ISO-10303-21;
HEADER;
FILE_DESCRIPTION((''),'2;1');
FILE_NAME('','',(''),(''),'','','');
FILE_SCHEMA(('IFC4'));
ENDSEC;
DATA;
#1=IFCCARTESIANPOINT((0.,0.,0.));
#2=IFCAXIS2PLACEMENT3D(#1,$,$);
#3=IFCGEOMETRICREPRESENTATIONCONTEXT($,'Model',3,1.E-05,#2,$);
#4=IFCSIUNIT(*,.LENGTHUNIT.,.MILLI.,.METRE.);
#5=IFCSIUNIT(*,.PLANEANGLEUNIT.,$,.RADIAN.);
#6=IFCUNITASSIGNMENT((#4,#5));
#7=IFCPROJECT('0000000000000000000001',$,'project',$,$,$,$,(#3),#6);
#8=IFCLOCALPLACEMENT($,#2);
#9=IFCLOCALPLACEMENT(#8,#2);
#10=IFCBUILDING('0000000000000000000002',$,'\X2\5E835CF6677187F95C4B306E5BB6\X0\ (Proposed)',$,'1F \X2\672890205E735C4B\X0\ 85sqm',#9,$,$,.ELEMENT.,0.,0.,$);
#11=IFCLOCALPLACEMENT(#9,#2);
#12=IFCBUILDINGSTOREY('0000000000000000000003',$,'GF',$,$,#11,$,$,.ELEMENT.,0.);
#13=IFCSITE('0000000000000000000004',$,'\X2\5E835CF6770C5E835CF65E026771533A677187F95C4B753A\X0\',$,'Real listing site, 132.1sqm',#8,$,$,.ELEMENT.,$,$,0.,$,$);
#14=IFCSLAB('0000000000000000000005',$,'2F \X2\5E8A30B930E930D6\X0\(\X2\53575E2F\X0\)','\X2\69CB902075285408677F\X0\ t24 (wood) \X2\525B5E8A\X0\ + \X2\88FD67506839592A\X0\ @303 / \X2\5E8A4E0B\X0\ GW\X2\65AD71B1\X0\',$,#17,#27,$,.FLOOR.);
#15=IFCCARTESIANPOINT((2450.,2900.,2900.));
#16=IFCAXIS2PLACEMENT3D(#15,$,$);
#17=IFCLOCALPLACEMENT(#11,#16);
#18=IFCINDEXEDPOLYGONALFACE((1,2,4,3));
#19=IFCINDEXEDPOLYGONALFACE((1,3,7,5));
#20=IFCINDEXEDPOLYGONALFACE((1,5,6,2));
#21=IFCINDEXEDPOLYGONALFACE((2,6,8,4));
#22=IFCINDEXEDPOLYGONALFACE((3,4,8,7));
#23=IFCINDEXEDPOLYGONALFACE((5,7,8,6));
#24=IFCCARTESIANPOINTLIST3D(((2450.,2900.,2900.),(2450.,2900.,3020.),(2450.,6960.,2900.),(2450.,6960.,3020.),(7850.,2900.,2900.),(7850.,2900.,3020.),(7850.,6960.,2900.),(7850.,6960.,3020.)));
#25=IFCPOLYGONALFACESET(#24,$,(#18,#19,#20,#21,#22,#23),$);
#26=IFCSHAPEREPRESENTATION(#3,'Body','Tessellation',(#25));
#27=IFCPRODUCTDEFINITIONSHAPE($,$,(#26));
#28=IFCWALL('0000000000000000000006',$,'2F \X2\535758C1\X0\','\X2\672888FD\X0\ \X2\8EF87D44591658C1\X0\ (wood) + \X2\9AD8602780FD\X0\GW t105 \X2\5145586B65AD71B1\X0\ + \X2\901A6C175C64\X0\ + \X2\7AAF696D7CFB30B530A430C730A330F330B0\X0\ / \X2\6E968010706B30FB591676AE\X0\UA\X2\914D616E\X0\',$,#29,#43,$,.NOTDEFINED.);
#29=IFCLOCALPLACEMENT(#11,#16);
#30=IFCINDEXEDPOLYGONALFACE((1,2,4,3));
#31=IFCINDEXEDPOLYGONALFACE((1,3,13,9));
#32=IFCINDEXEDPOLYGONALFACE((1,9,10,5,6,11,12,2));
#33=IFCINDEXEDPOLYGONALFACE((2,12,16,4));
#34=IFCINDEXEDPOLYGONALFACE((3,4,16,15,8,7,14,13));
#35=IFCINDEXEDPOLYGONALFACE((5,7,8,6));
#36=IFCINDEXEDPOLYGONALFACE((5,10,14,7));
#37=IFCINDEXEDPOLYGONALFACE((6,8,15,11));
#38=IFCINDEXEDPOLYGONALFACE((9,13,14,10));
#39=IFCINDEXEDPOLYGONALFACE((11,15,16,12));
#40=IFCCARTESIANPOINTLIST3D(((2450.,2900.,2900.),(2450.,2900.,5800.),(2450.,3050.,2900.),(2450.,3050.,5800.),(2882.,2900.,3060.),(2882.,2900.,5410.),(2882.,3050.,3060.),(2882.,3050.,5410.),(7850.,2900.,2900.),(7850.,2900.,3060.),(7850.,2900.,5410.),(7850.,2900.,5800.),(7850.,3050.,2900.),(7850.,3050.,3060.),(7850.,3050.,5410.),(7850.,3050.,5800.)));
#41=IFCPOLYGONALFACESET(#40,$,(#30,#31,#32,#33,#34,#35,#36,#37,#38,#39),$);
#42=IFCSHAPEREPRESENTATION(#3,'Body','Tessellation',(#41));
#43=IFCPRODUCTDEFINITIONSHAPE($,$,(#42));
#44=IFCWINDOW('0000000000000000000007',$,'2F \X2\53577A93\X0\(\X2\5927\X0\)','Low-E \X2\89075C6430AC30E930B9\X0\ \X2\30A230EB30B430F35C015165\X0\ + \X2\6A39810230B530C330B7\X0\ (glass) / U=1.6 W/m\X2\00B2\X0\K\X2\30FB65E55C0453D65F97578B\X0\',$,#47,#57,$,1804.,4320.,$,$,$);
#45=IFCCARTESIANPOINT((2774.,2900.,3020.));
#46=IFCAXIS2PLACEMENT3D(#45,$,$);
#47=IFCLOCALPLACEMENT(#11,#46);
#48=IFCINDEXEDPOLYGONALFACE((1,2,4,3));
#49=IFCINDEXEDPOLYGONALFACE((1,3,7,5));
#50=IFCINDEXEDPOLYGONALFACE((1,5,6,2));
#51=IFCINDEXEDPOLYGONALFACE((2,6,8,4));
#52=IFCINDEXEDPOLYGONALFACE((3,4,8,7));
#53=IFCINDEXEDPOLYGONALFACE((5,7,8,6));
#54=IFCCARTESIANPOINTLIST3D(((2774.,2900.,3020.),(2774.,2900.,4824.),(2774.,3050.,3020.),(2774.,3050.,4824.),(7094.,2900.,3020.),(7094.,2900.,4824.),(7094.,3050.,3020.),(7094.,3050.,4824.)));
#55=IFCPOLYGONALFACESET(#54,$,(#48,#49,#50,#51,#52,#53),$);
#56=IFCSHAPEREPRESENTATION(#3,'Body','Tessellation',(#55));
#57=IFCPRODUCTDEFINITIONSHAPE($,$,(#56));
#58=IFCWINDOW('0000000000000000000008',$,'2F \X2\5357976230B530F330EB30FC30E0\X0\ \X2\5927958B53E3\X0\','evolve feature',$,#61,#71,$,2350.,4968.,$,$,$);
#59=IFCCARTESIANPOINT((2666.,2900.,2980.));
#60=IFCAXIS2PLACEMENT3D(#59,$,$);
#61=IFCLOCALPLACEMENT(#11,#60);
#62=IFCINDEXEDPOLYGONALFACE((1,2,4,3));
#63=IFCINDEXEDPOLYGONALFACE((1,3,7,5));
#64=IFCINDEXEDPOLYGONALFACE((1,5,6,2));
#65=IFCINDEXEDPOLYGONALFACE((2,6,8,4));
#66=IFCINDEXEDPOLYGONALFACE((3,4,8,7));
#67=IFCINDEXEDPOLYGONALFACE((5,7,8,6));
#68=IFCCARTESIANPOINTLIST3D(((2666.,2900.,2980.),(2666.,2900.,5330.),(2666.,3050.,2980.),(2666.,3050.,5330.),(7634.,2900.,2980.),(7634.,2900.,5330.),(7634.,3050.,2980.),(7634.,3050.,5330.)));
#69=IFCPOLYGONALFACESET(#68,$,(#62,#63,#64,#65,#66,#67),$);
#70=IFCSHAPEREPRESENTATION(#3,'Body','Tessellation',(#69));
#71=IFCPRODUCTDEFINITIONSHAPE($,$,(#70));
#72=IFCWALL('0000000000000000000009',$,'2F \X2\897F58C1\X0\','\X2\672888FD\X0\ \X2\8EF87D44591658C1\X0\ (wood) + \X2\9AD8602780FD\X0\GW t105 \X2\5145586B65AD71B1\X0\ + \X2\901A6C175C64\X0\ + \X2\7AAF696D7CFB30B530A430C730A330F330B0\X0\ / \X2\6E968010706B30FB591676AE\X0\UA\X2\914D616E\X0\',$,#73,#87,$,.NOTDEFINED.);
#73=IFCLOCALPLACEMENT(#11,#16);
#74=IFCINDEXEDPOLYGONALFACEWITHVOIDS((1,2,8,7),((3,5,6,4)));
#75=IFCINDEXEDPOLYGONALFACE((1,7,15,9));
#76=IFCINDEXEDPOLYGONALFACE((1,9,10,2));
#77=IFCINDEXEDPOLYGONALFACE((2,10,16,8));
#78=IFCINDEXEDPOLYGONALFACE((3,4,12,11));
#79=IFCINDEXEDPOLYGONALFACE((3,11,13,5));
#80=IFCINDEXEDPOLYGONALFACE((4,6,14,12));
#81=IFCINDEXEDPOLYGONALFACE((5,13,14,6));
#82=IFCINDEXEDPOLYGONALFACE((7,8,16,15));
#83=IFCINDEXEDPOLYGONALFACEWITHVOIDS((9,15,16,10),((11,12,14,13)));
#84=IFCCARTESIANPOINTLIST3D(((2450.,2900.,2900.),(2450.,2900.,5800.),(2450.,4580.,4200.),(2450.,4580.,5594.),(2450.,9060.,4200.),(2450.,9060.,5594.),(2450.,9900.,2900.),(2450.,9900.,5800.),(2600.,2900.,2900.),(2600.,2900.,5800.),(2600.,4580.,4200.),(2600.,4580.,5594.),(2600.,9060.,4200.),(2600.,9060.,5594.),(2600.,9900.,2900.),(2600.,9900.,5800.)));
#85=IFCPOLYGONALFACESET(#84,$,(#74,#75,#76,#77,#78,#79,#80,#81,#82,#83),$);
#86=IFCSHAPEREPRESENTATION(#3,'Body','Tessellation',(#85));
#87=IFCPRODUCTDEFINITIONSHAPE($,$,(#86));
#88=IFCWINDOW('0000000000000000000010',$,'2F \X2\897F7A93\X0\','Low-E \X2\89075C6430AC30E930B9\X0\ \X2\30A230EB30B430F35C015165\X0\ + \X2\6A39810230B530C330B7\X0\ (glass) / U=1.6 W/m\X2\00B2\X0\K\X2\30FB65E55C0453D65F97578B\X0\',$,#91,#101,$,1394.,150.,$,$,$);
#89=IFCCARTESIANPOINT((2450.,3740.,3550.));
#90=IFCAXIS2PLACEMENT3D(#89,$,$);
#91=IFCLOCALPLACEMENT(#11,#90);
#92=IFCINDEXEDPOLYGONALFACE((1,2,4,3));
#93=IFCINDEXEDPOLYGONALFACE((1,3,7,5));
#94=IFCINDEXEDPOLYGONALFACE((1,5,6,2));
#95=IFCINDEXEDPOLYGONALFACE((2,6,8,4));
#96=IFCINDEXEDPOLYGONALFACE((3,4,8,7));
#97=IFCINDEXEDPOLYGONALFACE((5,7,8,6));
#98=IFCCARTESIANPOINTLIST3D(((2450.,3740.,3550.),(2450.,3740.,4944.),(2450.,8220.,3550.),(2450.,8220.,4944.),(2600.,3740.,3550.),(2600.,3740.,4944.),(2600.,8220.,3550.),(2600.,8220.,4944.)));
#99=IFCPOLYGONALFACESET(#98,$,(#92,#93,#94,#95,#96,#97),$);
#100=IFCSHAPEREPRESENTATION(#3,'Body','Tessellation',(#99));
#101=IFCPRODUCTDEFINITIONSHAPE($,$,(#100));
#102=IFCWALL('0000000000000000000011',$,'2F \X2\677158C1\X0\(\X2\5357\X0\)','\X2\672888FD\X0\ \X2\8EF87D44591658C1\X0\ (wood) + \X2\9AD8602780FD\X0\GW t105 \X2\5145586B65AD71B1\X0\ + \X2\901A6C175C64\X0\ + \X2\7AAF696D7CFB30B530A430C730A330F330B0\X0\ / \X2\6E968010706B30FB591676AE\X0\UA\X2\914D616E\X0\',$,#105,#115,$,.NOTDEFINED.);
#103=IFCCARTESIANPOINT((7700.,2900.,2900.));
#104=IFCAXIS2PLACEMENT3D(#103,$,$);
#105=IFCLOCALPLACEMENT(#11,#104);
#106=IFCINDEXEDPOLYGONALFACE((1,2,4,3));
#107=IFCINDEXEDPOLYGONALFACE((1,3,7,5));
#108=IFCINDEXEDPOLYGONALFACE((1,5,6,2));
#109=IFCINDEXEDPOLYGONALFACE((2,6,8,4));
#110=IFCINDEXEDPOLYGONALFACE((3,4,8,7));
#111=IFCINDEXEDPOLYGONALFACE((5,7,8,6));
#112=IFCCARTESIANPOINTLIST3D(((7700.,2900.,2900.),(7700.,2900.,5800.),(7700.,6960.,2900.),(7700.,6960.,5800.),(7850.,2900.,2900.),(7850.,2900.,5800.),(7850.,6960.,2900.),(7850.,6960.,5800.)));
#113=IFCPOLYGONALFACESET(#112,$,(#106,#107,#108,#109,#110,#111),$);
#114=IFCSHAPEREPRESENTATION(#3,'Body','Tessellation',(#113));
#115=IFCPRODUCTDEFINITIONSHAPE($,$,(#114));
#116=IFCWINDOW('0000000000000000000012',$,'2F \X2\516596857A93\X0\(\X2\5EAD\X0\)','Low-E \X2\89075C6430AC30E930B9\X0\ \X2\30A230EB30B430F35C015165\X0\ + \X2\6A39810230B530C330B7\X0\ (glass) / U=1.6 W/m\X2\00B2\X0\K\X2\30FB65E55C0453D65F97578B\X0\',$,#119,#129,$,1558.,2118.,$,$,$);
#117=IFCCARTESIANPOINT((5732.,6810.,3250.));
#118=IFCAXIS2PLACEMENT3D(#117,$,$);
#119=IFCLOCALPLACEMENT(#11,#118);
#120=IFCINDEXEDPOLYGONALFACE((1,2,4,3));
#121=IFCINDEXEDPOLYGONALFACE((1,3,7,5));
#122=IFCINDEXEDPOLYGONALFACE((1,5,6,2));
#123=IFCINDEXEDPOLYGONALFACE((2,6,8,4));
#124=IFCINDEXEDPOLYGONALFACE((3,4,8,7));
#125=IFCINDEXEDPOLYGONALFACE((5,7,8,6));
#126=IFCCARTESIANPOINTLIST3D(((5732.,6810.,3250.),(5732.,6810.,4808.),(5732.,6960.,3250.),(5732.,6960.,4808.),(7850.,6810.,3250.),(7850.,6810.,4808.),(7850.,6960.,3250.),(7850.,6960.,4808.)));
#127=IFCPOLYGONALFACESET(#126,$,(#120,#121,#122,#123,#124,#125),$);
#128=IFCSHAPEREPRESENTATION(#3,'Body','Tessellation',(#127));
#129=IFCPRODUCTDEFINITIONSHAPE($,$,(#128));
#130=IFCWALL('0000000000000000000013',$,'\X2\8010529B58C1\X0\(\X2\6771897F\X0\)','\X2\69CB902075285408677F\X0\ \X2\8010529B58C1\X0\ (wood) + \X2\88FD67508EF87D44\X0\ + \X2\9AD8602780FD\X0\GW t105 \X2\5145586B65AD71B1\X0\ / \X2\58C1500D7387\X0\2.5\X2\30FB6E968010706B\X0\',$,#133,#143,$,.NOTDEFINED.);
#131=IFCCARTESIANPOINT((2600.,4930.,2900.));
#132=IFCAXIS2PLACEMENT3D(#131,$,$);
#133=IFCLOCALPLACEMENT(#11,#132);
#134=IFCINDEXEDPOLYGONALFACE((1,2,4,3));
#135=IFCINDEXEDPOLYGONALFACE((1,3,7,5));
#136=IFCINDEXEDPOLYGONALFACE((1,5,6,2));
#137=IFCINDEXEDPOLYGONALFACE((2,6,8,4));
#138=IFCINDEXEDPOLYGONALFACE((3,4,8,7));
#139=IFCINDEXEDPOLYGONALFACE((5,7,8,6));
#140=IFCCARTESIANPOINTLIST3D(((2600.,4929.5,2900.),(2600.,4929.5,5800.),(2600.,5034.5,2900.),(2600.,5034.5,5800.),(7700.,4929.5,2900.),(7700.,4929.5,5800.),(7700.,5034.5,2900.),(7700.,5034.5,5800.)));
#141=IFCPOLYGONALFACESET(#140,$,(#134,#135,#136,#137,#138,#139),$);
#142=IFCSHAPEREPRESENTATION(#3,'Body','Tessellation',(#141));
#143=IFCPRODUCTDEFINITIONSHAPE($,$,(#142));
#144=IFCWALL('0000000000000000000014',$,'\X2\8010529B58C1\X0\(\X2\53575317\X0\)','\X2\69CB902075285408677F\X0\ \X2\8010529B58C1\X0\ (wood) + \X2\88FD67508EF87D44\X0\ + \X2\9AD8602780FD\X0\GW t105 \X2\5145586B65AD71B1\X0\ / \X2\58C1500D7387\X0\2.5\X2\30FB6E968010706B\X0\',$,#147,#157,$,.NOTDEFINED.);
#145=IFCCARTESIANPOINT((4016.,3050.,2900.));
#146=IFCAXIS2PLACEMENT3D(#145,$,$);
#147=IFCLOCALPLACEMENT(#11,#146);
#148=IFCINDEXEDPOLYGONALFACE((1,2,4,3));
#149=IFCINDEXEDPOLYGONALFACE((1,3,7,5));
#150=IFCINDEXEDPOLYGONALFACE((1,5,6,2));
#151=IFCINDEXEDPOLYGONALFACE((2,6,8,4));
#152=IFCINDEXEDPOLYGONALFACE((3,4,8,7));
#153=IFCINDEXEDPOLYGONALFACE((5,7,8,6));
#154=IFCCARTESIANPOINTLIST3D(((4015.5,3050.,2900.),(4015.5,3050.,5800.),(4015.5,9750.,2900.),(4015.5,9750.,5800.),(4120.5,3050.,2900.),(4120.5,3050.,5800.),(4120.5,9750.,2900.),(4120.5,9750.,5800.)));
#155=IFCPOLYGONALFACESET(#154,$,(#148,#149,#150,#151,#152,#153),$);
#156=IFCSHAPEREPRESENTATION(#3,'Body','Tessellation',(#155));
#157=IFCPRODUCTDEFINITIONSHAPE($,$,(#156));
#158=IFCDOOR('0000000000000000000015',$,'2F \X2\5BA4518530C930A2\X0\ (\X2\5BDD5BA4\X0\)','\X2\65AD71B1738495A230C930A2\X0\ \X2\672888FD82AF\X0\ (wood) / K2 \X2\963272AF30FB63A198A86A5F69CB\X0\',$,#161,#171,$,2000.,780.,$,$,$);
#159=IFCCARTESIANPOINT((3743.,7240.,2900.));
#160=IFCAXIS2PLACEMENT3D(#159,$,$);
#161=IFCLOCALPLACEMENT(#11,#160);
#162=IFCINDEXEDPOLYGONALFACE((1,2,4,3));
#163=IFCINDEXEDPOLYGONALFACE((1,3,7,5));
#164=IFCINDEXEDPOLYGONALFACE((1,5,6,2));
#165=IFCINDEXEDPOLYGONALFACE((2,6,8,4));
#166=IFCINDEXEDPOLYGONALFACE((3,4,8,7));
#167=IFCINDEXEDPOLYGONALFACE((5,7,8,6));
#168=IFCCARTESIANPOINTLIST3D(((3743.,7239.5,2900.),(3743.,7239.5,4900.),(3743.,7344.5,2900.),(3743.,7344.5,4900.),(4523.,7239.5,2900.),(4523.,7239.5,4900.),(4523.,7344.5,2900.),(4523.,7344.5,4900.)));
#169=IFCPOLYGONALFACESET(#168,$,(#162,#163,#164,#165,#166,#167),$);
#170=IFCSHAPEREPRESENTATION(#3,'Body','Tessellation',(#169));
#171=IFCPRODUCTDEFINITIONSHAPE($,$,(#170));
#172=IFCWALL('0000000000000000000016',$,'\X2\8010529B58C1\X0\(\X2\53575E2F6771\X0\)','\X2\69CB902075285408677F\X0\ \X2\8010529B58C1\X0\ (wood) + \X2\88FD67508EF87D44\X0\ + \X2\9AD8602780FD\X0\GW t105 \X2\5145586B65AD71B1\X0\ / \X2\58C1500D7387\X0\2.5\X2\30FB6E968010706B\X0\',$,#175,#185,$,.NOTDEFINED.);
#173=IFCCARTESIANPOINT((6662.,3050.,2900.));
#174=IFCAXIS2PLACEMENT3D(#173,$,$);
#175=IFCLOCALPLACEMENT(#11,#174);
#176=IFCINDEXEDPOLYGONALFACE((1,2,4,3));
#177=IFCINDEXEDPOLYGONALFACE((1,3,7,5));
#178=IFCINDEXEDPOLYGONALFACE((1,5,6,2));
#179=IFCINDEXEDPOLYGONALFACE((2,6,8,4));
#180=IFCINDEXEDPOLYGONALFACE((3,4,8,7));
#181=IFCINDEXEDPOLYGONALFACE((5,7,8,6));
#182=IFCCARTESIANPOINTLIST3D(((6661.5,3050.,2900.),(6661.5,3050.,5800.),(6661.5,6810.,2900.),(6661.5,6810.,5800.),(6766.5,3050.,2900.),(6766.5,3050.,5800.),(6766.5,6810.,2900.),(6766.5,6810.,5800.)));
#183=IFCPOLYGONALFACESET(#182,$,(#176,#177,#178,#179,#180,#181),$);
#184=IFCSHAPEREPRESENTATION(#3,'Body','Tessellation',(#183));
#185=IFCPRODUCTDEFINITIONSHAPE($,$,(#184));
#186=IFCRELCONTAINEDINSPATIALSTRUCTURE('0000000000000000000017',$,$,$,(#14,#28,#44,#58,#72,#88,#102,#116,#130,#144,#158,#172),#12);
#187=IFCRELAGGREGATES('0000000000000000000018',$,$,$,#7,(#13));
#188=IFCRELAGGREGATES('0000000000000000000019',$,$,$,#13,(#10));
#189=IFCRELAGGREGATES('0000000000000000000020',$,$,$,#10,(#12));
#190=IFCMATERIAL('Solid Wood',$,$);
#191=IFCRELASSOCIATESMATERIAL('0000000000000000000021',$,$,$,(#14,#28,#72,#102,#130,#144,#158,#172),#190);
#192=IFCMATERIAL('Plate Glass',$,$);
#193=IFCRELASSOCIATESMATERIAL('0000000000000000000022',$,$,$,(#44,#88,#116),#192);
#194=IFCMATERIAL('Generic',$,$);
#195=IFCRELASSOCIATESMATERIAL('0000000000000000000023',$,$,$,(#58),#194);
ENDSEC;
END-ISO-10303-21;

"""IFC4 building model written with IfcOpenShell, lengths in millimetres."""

from ifc_helpers import new_model, si_unit, frame, frame_2d, origin, place, context, project, spatial, rectangle, extrude, material, element, fill, save


model = new_model("IFC4")

# Units and contexts
model_context = context("Model", 3, precision=1e-05, world=origin())
ifc_project = project(units=[si_unit("LENGTHUNIT", "METRE", prefix="MILLI"), si_unit("PLANEANGLEUNIT", "RADIAN")], contexts=[model_context])

# Site, building, storey
site_placement = place(None, origin())
site = spatial("IfcSite", under=ifc_project, at=site_placement, Name="広島県広島市東区東蟹屋町", ObjectType="Real listing site, 132.1sqm", CompositionType="ELEMENT", RefElevation=0.0)
building_placement = place(site_placement, origin())
building = spatial("IfcBuilding", under=site, at=building_placement, Name="広島東蟹屋の家 (Proposed)", ObjectType="1F 木造平屋 85sqm", CompositionType="ELEMENT", ElevationOfRefHeight=0.0, ElevationOfTerrain=0.0)
storey_placement = place(building_placement, origin())
storey = spatial("IfcBuildingStorey", under=building, at=storey_placement, Name="GF", CompositionType="ELEMENT", Elevation=0.0)

# Slab
ifc_material_1 = material(Name="Solid Wood")
slab_placement = place(storey_placement, frame((2450.0, 2900.0, 2900.0)))
element("IfcSlab", 1, at=slab_placement, inside=storey, material=ifc_material_1, Name="2F 床スラブ(南帯)", Description="構造用合板 t24 (wood) 剛床 + 製材根太 @303 / 床下 GW断熱", PredefinedType="FLOOR", context=model_context, shape_type="SweptSolid", body=[
    extrude(rectangle(XDim=5400.0, YDim=4060.0, at=frame_2d((2700.0, 2030.0))), frame((2450.0, 2900.0, 2900.0)), (0.0, 0.0, 1.0), 120.0),
])

# Wall, openings, windows
wall_1_placement = place(storey_placement, frame((2450.0, 2900.0, 2900.0)))
wall_1 = element("IfcWall", 2, at=wall_1_placement, inside=storey, material=ifc_material_1, Name="2F 南壁", Description="木製 軸組外壁 (wood) + 高性能GW t105 充填断熱 + 通気層 + 窯業系サイディング / 準耐火・外皮UA配慮", PredefinedType="NOTDEFINED", context=model_context, shape_type="SweptSolid", body=[
    extrude(rectangle(XDim=5400.0, YDim=150.0, at=frame_2d((2700.0, 75.0))), frame((2450.0, 2900.0, 2900.0)), (0.0, 0.0, 1.0), 2900.0),
])
opening_1_placement = place(storey_placement, frame((2774.0, 2900.0, 3020.0)))
opening_1 = element("IfcOpeningElement", 3, at=opening_1_placement, cuts=wall_1, PredefinedType="NOTDEFINED", context=model_context, shape_type="SweptSolid", body=[
    extrude(rectangle(XDim=4320.0, YDim=150.0, at=frame_2d((2160.0, 75.0))), frame((2774.0, 2900.0, 3020.0)), (0.0, 0.0, 1.0), 1804.0),
])
opening_2_placement = place(storey_placement, frame((2666.0, 2900.0, 2980.0)))
opening_2 = element("IfcOpeningElement", 4, at=opening_2_placement, cuts=wall_1, PredefinedType="NOTDEFINED", context=model_context, shape_type="SweptSolid", body=[
    extrude(rectangle(XDim=4968.0, YDim=150.0, at=frame_2d((2484.0, 75.0))), frame((2666.0, 2900.0, 2980.0)), (0.0, 0.0, 1.0), 2350.0),
])
ifc_material_2 = material(Name="Plate Glass")
window_1_placement = place(storey_placement, frame((2774.0, 2900.0, 3020.0)))
window_1 = element("IfcWindow", 5, at=window_1_placement, inside=storey, material=ifc_material_2, Name="2F 南窓(大)", Description="Low-E 複層ガラス アルゴン封入 + 樹脂サッシ (glass) / U=1.6 W/m²K・日射取得型", OverallHeight=1804.0, OverallWidth=4320.0, context=model_context, shape_type="SweptSolid", body=[
    extrude(rectangle(XDim=4320.0, YDim=150.0, at=frame_2d((2160.0, 75.0))), frame((2774.0, 2900.0, 3020.0)), (0.0, 0.0, 1.0), 1804.0),
])
fill(opening_1, window_1)
ifc_material_3 = material(Name="Generic")
window_2_placement = place(storey_placement, frame((2666.0, 2900.0, 2980.0)))
window_2 = element("IfcWindow", 6, at=window_2_placement, inside=storey, material=ifc_material_3, Name="2F 南面サンルーム 大開口", Description="evolve feature", OverallHeight=2350.0, OverallWidth=4968.0, context=model_context, shape_type="SweptSolid", body=[
    extrude(rectangle(XDim=4968.0, YDim=150.0, at=frame_2d((2484.0, 75.0))), frame((2666.0, 2900.0, 2980.0)), (0.0, 0.0, 1.0), 2350.0),
])
fill(opening_2, window_2)

# Walls, openings, windows
wall_2_placement = place(storey_placement, frame((2450.0, 2900.0, 2900.0)))
wall_2 = element("IfcWall", 7, at=wall_2_placement, inside=storey, material=ifc_material_1, Name="2F 西壁", Description="木製 軸組外壁 (wood) + 高性能GW t105 充填断熱 + 通気層 + 窯業系サイディング / 準耐火・外皮UA配慮", PredefinedType="NOTDEFINED", context=model_context, shape_type="SweptSolid", body=[
    extrude(rectangle(XDim=150.0, YDim=7000.0, at=frame_2d((75.0, 3500.0))), frame((2450.0, 2900.0, 2900.0)), (0.0, 0.0, 1.0), 2900.0),
])
opening_3_placement = place(storey_placement, frame((2450.0, 3740.0, 3550.0)))
opening_3 = element("IfcOpeningElement", 8, at=opening_3_placement, cuts=wall_2, PredefinedType="NOTDEFINED", context=model_context, shape_type="SweptSolid", body=[
    extrude(rectangle(XDim=150.0, YDim=4480.0, at=frame_2d((75.0, 2240.0))), frame((2450.0, 3740.0, 3550.0)), (0.0, 0.0, 1.0), 1394.0),
])
window_3_placement = place(storey_placement, frame((2450.0, 3740.0, 3550.0)))
window_3 = element("IfcWindow", 9, at=window_3_placement, inside=storey, material=ifc_material_2, Name="2F 西窓", Description="Low-E 複層ガラス アルゴン封入 + 樹脂サッシ (glass) / U=1.6 W/m²K・日射取得型", OverallHeight=1394.0, OverallWidth=150.0, context=model_context, shape_type="SweptSolid", body=[
    extrude(rectangle(XDim=150.0, YDim=4480.0, at=frame_2d((75.0, 2240.0))), frame((2450.0, 3740.0, 3550.0)), (0.0, 0.0, 1.0), 1394.0),
])
fill(opening_3, window_3)
wall_3_placement = place(storey_placement, frame((7700.0, 2900.0, 2900.0)))
wall_3 = element("IfcWall", 10, at=wall_3_placement, inside=storey, material=ifc_material_1, Name="2F 東壁(南)", Description="木製 軸組外壁 (wood) + 高性能GW t105 充填断熱 + 通気層 + 窯業系サイディング / 準耐火・外皮UA配慮", PredefinedType="NOTDEFINED", context=model_context, shape_type="SweptSolid", body=[
    extrude(rectangle(XDim=150.0, YDim=4060.0, at=frame_2d((75.0, 2030.0))), frame((7700.0, 2900.0, 2900.0)), (0.0, 0.0, 1.0), 2900.0),
])
opening_4_placement = place(storey_placement, frame((5732.0, 6810.0, 3250.0)))
opening_4 = element("IfcOpeningElement", 11, at=opening_4_placement, cuts=wall_3, PredefinedType="NOTDEFINED", context=model_context, shape_type="SweptSolid", body=[
    extrude(rectangle(XDim=2118.0, YDim=150.0, at=frame_2d((1059.0, 75.0))), frame((5732.0, 6810.0, 3250.0)), (0.0, 0.0, 1.0), 1558.0),
])
window_4_placement = place(storey_placement, frame((5732.0, 6810.0, 3250.0)))
window_4 = element("IfcWindow", 12, at=window_4_placement, inside=storey, material=ifc_material_2, Name="2F 入隅窓(庭)", Description="Low-E 複層ガラス アルゴン封入 + 樹脂サッシ (glass) / U=1.6 W/m²K・日射取得型", OverallHeight=1558.0, OverallWidth=2118.0, context=model_context, shape_type="SweptSolid", body=[
    extrude(rectangle(XDim=2118.0, YDim=150.0, at=frame_2d((1059.0, 75.0))), frame((5732.0, 6810.0, 3250.0)), (0.0, 0.0, 1.0), 1558.0),
])
fill(opening_4, window_4)

# Wall
wall_4_placement = place(storey_placement, frame((2600.0, 4930.0, 2900.0)))
element("IfcWall", 13, at=wall_4_placement, inside=storey, material=ifc_material_1, Name="耐力壁(東西)", Description="構造用合板 耐力壁 (wood) + 製材軸組 + 高性能GW t105 充填断熱 / 壁倍率2.5・準耐火", PredefinedType="NOTDEFINED", context=model_context, shape_type="SweptSolid", body=[
    extrude(rectangle(XDim=5100.0, YDim=105.0, at=frame_2d((2550.0, 52.0))), frame((2600.0, 4930.0, 2900.0)), (0.0, 0.0, 1.0), 2900.0),
])

# Wall, opening, door
wall_5_placement = place(storey_placement, frame((4016.0, 3050.0, 2900.0)))
wall_5 = element("IfcWall", 14, at=wall_5_placement, inside=storey, material=ifc_material_1, Name="耐力壁(南北)", Description="構造用合板 耐力壁 (wood) + 製材軸組 + 高性能GW t105 充填断熱 / 壁倍率2.5・準耐火", PredefinedType="NOTDEFINED", context=model_context, shape_type="SweptSolid", body=[
    extrude(rectangle(XDim=105.0, YDim=6700.0, at=frame_2d((52.0, 3350.0))), frame((4016.0, 3050.0, 2900.0)), (0.0, 0.0, 1.0), 2900.0),
])
opening_5_placement = place(storey_placement, frame((3743.0, 7240.0, 2900.0)))
opening_5 = element("IfcOpeningElement", 15, at=opening_5_placement, cuts=wall_5, PredefinedType="NOTDEFINED", context=model_context, shape_type="SweptSolid", body=[
    extrude(rectangle(XDim=780.0, YDim=105.0, at=frame_2d((390.0, 52.0))), frame((3743.0, 7240.0, 2900.0)), (0.0, 0.0, 1.0), 2000.0),
])
door_placement = place(storey_placement, frame((3743.0, 7240.0, 2900.0)))
door = element("IfcDoor", 16, at=door_placement, inside=storey, material=ifc_material_1, Name="2F 室内ドア (寝室)", Description="断熱玄関ドア 木製芯 (wood) / K2 防犯・採風機構", OverallHeight=2000.0, OverallWidth=780.0, context=model_context, shape_type="SweptSolid", body=[
    extrude(rectangle(XDim=780.0, YDim=105.0, at=frame_2d((390.0, 52.0))), frame((3743.0, 7240.0, 2900.0)), (0.0, 0.0, 1.0), 2000.0),
])
fill(opening_5, door)

# Wall
wall_6_placement = place(storey_placement, frame((6662.0, 3050.0, 2900.0)))
element("IfcWall", 17, at=wall_6_placement, inside=storey, material=ifc_material_1, Name="耐力壁(南帯東)", Description="構造用合板 耐力壁 (wood) + 製材軸組 + 高性能GW t105 充填断熱 / 壁倍率2.5・準耐火", PredefinedType="NOTDEFINED", context=model_context, shape_type="SweptSolid", body=[
    extrude(rectangle(XDim=105.0, YDim=3760.0, at=frame_2d((52.0, 1880.0))), frame((6662.0, 3050.0, 2900.0)), (0.0, 0.0, 1.0), 2900.0),
])

save(model, "model.ifc")
